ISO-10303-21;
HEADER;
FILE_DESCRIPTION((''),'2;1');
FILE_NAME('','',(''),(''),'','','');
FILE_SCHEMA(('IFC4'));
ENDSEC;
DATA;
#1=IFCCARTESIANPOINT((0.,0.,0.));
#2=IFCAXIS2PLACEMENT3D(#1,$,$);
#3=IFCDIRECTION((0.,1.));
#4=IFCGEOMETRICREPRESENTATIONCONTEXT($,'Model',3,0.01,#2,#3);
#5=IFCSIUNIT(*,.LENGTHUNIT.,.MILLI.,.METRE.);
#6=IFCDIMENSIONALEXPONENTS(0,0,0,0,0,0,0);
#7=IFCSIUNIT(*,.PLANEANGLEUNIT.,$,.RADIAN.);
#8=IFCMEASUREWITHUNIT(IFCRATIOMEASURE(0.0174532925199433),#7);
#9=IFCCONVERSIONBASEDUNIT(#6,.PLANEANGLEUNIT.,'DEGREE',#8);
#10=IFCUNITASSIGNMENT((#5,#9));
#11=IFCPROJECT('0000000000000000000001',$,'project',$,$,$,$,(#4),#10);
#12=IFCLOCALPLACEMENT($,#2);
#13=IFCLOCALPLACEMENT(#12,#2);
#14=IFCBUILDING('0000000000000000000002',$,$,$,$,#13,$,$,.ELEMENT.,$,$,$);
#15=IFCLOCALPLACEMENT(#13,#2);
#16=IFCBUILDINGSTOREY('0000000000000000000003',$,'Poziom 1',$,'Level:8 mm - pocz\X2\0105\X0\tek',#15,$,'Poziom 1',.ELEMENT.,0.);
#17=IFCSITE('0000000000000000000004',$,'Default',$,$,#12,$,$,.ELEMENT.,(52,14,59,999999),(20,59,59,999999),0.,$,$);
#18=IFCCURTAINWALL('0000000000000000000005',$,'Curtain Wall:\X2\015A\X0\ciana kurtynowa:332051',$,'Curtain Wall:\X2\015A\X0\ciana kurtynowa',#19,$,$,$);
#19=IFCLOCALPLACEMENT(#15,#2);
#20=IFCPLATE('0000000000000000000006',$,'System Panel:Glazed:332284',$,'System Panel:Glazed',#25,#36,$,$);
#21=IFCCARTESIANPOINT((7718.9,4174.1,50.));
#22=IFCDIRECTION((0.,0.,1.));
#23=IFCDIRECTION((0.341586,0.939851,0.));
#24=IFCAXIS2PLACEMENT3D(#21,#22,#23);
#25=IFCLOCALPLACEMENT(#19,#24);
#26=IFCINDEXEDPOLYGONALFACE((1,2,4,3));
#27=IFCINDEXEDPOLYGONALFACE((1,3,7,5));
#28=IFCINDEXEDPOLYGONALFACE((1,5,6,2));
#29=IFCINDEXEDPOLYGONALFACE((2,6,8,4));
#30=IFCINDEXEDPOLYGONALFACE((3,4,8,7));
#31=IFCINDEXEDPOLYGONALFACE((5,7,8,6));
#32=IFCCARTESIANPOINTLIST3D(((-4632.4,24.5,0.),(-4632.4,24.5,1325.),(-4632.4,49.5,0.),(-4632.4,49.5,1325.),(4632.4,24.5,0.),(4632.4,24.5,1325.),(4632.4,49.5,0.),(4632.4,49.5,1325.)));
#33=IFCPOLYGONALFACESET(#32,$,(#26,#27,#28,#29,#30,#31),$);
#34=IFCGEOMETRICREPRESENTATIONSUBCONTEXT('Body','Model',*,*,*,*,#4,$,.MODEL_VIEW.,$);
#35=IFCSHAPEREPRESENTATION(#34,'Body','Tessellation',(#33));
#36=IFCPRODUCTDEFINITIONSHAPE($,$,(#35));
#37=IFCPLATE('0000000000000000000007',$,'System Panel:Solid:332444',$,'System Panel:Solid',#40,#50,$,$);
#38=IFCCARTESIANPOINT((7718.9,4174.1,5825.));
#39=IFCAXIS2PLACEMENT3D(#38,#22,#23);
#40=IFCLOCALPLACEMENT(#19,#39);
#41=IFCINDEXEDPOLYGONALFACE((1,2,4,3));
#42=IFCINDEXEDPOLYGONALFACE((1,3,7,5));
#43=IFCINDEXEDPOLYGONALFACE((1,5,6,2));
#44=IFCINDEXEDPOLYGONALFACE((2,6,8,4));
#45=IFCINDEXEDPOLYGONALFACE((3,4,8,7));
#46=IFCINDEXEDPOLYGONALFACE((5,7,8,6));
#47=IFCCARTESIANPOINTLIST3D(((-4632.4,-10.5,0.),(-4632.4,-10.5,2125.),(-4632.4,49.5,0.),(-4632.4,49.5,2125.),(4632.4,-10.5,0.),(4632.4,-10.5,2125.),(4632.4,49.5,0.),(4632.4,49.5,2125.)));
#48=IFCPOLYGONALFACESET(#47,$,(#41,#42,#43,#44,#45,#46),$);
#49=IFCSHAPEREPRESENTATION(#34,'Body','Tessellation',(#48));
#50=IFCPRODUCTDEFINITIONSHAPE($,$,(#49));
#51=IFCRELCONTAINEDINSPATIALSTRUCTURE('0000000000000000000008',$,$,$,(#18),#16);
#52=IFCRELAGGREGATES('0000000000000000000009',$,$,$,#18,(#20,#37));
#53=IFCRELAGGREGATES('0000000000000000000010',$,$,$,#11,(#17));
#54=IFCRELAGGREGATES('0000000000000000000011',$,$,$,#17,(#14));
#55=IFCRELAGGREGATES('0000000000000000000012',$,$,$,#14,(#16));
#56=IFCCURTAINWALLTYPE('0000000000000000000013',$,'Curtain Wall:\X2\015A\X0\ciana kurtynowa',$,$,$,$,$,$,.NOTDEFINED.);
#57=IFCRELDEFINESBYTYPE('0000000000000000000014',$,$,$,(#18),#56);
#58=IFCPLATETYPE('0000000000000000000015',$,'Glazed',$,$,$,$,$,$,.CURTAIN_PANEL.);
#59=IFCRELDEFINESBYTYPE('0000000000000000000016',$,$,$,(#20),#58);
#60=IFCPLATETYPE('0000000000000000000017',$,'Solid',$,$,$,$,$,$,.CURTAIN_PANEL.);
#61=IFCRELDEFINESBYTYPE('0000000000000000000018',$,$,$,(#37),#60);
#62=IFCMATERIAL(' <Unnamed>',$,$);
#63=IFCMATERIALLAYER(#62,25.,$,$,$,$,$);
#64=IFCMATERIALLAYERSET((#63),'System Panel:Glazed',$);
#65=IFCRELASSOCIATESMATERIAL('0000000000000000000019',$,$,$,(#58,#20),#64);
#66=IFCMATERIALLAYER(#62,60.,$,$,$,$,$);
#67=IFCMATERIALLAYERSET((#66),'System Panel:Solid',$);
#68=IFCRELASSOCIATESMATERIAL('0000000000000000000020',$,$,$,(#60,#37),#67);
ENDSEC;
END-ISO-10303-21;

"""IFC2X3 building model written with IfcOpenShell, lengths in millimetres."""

from ifc_helpers import new_model, entity, si_unit, converted_unit, direction, frame, frame_2d, origin, origin_2d_with_axis, place, context, subcontext, project, spatial, rectangle, extrude, source, transform, mapped, material, layer, layer_set, layer_usage, type_object, type_shapes, element, aggregate, save


model = new_model("IFC2X3")

# Units and contexts
model_context = context("Model", 3, precision=0.01, world=origin(), true_north=direction((0.0, 1.0)))
body_context = subcontext(model_context, "Body", "Model", "MODEL_VIEW")
ifc_project = project(units=[si_unit("LENGTHUNIT", "METRE", prefix="MILLI"), converted_unit("PLANEANGLEUNIT", "DEGREE", entity("IfcRatioMeasure", 0.0174532925199433), si_unit("PLANEANGLEUNIT", "RADIAN"), dimensions=[0, 0, 0, 0, 0, 0, 0])], contexts=[model_context])

# Site, building, storey
site_placement = place(None, origin())
site = spatial("IfcSite", under=ifc_project, at=site_placement, Name="Default", CompositionType="ELEMENT", RefLatitude=(52, 14, 59, 999999), RefLongitude=(20, 59, 59, 999999), RefElevation=0.0)
building_placement = place(site_placement, origin())
building = spatial("IfcBuilding", under=site, at=building_placement, CompositionType="ELEMENT")
storey_placement = place(building_placement, origin())
storey = spatial("IfcBuildingStorey", under=building, at=storey_placement, Name="Poziom 1", ObjectType="Level:8 mm - początek", LongName="Poziom 1", CompositionType="ELEMENT", Elevation=0.0)

# Curtain wall, plates
curtain_wall_type = type_object("IfcCurtainWallType", Name="Curtain Wall:Ściana kurtynowa", PredefinedType="NOTDEFINED")
curtain_wall_placement = place(storey_placement, origin())
curtain_wall = element("IfcCurtainWall", 1, at=curtain_wall_placement, inside=storey, type_object=curtain_wall_type, Name="Curtain Wall:Ściana kurtynowa:332051", ObjectType="Curtain Wall:Ściana kurtynowa")
ifc_material_1 = material(Name=" <Unnamed>")
ifc_layer_1 = layer(ifc_material_1, 25.0)
ifc_layer_set_1 = layer_set([ifc_layer_1], Name="System Panel:Glazed")
ifc_layer_usage_1 = layer_usage(ifc_layer_set_1, "AXIS3", "POSITIVE", 0.1)
plate_type_1 = type_object("IfcPlateType", Name="Glazed", PredefinedType="CURTAIN_PANEL", material=ifc_layer_set_1)
shared_shape_1 = source(origin(), body_context, "Body", "SweptSolid", [
    extrude(rectangle(XDim=25.0, YDim=9264.9, at=frame_2d((0.0, 0.0), x_axis=(1.0, 0.0))), frame((0.0, 37.0, 0.0), z_axis=(0.0, 0.0, 1.0), x_axis=(0.0, 1.0, 0.0)), (0.0, 0.0, 1.0), 1325.0),
])
type_shapes(plate_type_1, [shared_shape_1])
plate_1_placement = place(curtain_wall_placement, frame((7718.9, 4174.1, 50.0), z_axis=(0.0, 0.0, 1.0), x_axis=(0.341586, 0.939851, 0.0)))
plate_1 = element("IfcPlate", 2, at=plate_1_placement, type_object=plate_type_1, material=ifc_layer_usage_1, Name="System Panel:Glazed:332284", ObjectType="System Panel:Glazed", context=body_context, shape_type="MappedRepresentation", body=[
    mapped(shared_shape_1, transform((0.0, 0.0, 0.0), scale=1.0)),
])
ifc_layer_2 = layer(ifc_material_1, 60.0)
ifc_layer_set_2 = layer_set([ifc_layer_2], Name="System Panel:Solid")
ifc_layer_usage_2 = layer_usage(ifc_layer_set_2, "AXIS3", "POSITIVE", 0.1)
plate_type_2 = type_object("IfcPlateType", Name="Solid", PredefinedType="CURTAIN_PANEL", material=ifc_layer_set_2)
shared_shape_2 = source(origin(), body_context, "Body", "SweptSolid", [
    extrude(rectangle(XDim=60.0, YDim=9264.9, at=origin_2d_with_axis()), frame((0.0, 19.5, 0.0), z_axis=(0.0, 0.0, 1.0), x_axis=(0.0, 1.0, 0.0)), (0.0, 0.0, 1.0), 2125.0),
])
type_shapes(plate_type_2, [shared_shape_2])
plate_2_placement = place(curtain_wall_placement, frame((7718.9, 4174.1, 5825.0), z_axis=(0.0, 0.0, 1.0), x_axis=(0.341586, 0.939851, 0.0)))
plate_2 = element("IfcPlate", 3, at=plate_2_placement, type_object=plate_type_2, material=ifc_layer_usage_2, Name="System Panel:Solid:332444", ObjectType="System Panel:Solid", context=body_context, shape_type="MappedRepresentation", body=[
    mapped(shared_shape_2, transform((0.0, 0.0, 0.0), scale=1.0)),
])
aggregate(curtain_wall, [plate_1, plate_2])

save(model, "model.ifc")
